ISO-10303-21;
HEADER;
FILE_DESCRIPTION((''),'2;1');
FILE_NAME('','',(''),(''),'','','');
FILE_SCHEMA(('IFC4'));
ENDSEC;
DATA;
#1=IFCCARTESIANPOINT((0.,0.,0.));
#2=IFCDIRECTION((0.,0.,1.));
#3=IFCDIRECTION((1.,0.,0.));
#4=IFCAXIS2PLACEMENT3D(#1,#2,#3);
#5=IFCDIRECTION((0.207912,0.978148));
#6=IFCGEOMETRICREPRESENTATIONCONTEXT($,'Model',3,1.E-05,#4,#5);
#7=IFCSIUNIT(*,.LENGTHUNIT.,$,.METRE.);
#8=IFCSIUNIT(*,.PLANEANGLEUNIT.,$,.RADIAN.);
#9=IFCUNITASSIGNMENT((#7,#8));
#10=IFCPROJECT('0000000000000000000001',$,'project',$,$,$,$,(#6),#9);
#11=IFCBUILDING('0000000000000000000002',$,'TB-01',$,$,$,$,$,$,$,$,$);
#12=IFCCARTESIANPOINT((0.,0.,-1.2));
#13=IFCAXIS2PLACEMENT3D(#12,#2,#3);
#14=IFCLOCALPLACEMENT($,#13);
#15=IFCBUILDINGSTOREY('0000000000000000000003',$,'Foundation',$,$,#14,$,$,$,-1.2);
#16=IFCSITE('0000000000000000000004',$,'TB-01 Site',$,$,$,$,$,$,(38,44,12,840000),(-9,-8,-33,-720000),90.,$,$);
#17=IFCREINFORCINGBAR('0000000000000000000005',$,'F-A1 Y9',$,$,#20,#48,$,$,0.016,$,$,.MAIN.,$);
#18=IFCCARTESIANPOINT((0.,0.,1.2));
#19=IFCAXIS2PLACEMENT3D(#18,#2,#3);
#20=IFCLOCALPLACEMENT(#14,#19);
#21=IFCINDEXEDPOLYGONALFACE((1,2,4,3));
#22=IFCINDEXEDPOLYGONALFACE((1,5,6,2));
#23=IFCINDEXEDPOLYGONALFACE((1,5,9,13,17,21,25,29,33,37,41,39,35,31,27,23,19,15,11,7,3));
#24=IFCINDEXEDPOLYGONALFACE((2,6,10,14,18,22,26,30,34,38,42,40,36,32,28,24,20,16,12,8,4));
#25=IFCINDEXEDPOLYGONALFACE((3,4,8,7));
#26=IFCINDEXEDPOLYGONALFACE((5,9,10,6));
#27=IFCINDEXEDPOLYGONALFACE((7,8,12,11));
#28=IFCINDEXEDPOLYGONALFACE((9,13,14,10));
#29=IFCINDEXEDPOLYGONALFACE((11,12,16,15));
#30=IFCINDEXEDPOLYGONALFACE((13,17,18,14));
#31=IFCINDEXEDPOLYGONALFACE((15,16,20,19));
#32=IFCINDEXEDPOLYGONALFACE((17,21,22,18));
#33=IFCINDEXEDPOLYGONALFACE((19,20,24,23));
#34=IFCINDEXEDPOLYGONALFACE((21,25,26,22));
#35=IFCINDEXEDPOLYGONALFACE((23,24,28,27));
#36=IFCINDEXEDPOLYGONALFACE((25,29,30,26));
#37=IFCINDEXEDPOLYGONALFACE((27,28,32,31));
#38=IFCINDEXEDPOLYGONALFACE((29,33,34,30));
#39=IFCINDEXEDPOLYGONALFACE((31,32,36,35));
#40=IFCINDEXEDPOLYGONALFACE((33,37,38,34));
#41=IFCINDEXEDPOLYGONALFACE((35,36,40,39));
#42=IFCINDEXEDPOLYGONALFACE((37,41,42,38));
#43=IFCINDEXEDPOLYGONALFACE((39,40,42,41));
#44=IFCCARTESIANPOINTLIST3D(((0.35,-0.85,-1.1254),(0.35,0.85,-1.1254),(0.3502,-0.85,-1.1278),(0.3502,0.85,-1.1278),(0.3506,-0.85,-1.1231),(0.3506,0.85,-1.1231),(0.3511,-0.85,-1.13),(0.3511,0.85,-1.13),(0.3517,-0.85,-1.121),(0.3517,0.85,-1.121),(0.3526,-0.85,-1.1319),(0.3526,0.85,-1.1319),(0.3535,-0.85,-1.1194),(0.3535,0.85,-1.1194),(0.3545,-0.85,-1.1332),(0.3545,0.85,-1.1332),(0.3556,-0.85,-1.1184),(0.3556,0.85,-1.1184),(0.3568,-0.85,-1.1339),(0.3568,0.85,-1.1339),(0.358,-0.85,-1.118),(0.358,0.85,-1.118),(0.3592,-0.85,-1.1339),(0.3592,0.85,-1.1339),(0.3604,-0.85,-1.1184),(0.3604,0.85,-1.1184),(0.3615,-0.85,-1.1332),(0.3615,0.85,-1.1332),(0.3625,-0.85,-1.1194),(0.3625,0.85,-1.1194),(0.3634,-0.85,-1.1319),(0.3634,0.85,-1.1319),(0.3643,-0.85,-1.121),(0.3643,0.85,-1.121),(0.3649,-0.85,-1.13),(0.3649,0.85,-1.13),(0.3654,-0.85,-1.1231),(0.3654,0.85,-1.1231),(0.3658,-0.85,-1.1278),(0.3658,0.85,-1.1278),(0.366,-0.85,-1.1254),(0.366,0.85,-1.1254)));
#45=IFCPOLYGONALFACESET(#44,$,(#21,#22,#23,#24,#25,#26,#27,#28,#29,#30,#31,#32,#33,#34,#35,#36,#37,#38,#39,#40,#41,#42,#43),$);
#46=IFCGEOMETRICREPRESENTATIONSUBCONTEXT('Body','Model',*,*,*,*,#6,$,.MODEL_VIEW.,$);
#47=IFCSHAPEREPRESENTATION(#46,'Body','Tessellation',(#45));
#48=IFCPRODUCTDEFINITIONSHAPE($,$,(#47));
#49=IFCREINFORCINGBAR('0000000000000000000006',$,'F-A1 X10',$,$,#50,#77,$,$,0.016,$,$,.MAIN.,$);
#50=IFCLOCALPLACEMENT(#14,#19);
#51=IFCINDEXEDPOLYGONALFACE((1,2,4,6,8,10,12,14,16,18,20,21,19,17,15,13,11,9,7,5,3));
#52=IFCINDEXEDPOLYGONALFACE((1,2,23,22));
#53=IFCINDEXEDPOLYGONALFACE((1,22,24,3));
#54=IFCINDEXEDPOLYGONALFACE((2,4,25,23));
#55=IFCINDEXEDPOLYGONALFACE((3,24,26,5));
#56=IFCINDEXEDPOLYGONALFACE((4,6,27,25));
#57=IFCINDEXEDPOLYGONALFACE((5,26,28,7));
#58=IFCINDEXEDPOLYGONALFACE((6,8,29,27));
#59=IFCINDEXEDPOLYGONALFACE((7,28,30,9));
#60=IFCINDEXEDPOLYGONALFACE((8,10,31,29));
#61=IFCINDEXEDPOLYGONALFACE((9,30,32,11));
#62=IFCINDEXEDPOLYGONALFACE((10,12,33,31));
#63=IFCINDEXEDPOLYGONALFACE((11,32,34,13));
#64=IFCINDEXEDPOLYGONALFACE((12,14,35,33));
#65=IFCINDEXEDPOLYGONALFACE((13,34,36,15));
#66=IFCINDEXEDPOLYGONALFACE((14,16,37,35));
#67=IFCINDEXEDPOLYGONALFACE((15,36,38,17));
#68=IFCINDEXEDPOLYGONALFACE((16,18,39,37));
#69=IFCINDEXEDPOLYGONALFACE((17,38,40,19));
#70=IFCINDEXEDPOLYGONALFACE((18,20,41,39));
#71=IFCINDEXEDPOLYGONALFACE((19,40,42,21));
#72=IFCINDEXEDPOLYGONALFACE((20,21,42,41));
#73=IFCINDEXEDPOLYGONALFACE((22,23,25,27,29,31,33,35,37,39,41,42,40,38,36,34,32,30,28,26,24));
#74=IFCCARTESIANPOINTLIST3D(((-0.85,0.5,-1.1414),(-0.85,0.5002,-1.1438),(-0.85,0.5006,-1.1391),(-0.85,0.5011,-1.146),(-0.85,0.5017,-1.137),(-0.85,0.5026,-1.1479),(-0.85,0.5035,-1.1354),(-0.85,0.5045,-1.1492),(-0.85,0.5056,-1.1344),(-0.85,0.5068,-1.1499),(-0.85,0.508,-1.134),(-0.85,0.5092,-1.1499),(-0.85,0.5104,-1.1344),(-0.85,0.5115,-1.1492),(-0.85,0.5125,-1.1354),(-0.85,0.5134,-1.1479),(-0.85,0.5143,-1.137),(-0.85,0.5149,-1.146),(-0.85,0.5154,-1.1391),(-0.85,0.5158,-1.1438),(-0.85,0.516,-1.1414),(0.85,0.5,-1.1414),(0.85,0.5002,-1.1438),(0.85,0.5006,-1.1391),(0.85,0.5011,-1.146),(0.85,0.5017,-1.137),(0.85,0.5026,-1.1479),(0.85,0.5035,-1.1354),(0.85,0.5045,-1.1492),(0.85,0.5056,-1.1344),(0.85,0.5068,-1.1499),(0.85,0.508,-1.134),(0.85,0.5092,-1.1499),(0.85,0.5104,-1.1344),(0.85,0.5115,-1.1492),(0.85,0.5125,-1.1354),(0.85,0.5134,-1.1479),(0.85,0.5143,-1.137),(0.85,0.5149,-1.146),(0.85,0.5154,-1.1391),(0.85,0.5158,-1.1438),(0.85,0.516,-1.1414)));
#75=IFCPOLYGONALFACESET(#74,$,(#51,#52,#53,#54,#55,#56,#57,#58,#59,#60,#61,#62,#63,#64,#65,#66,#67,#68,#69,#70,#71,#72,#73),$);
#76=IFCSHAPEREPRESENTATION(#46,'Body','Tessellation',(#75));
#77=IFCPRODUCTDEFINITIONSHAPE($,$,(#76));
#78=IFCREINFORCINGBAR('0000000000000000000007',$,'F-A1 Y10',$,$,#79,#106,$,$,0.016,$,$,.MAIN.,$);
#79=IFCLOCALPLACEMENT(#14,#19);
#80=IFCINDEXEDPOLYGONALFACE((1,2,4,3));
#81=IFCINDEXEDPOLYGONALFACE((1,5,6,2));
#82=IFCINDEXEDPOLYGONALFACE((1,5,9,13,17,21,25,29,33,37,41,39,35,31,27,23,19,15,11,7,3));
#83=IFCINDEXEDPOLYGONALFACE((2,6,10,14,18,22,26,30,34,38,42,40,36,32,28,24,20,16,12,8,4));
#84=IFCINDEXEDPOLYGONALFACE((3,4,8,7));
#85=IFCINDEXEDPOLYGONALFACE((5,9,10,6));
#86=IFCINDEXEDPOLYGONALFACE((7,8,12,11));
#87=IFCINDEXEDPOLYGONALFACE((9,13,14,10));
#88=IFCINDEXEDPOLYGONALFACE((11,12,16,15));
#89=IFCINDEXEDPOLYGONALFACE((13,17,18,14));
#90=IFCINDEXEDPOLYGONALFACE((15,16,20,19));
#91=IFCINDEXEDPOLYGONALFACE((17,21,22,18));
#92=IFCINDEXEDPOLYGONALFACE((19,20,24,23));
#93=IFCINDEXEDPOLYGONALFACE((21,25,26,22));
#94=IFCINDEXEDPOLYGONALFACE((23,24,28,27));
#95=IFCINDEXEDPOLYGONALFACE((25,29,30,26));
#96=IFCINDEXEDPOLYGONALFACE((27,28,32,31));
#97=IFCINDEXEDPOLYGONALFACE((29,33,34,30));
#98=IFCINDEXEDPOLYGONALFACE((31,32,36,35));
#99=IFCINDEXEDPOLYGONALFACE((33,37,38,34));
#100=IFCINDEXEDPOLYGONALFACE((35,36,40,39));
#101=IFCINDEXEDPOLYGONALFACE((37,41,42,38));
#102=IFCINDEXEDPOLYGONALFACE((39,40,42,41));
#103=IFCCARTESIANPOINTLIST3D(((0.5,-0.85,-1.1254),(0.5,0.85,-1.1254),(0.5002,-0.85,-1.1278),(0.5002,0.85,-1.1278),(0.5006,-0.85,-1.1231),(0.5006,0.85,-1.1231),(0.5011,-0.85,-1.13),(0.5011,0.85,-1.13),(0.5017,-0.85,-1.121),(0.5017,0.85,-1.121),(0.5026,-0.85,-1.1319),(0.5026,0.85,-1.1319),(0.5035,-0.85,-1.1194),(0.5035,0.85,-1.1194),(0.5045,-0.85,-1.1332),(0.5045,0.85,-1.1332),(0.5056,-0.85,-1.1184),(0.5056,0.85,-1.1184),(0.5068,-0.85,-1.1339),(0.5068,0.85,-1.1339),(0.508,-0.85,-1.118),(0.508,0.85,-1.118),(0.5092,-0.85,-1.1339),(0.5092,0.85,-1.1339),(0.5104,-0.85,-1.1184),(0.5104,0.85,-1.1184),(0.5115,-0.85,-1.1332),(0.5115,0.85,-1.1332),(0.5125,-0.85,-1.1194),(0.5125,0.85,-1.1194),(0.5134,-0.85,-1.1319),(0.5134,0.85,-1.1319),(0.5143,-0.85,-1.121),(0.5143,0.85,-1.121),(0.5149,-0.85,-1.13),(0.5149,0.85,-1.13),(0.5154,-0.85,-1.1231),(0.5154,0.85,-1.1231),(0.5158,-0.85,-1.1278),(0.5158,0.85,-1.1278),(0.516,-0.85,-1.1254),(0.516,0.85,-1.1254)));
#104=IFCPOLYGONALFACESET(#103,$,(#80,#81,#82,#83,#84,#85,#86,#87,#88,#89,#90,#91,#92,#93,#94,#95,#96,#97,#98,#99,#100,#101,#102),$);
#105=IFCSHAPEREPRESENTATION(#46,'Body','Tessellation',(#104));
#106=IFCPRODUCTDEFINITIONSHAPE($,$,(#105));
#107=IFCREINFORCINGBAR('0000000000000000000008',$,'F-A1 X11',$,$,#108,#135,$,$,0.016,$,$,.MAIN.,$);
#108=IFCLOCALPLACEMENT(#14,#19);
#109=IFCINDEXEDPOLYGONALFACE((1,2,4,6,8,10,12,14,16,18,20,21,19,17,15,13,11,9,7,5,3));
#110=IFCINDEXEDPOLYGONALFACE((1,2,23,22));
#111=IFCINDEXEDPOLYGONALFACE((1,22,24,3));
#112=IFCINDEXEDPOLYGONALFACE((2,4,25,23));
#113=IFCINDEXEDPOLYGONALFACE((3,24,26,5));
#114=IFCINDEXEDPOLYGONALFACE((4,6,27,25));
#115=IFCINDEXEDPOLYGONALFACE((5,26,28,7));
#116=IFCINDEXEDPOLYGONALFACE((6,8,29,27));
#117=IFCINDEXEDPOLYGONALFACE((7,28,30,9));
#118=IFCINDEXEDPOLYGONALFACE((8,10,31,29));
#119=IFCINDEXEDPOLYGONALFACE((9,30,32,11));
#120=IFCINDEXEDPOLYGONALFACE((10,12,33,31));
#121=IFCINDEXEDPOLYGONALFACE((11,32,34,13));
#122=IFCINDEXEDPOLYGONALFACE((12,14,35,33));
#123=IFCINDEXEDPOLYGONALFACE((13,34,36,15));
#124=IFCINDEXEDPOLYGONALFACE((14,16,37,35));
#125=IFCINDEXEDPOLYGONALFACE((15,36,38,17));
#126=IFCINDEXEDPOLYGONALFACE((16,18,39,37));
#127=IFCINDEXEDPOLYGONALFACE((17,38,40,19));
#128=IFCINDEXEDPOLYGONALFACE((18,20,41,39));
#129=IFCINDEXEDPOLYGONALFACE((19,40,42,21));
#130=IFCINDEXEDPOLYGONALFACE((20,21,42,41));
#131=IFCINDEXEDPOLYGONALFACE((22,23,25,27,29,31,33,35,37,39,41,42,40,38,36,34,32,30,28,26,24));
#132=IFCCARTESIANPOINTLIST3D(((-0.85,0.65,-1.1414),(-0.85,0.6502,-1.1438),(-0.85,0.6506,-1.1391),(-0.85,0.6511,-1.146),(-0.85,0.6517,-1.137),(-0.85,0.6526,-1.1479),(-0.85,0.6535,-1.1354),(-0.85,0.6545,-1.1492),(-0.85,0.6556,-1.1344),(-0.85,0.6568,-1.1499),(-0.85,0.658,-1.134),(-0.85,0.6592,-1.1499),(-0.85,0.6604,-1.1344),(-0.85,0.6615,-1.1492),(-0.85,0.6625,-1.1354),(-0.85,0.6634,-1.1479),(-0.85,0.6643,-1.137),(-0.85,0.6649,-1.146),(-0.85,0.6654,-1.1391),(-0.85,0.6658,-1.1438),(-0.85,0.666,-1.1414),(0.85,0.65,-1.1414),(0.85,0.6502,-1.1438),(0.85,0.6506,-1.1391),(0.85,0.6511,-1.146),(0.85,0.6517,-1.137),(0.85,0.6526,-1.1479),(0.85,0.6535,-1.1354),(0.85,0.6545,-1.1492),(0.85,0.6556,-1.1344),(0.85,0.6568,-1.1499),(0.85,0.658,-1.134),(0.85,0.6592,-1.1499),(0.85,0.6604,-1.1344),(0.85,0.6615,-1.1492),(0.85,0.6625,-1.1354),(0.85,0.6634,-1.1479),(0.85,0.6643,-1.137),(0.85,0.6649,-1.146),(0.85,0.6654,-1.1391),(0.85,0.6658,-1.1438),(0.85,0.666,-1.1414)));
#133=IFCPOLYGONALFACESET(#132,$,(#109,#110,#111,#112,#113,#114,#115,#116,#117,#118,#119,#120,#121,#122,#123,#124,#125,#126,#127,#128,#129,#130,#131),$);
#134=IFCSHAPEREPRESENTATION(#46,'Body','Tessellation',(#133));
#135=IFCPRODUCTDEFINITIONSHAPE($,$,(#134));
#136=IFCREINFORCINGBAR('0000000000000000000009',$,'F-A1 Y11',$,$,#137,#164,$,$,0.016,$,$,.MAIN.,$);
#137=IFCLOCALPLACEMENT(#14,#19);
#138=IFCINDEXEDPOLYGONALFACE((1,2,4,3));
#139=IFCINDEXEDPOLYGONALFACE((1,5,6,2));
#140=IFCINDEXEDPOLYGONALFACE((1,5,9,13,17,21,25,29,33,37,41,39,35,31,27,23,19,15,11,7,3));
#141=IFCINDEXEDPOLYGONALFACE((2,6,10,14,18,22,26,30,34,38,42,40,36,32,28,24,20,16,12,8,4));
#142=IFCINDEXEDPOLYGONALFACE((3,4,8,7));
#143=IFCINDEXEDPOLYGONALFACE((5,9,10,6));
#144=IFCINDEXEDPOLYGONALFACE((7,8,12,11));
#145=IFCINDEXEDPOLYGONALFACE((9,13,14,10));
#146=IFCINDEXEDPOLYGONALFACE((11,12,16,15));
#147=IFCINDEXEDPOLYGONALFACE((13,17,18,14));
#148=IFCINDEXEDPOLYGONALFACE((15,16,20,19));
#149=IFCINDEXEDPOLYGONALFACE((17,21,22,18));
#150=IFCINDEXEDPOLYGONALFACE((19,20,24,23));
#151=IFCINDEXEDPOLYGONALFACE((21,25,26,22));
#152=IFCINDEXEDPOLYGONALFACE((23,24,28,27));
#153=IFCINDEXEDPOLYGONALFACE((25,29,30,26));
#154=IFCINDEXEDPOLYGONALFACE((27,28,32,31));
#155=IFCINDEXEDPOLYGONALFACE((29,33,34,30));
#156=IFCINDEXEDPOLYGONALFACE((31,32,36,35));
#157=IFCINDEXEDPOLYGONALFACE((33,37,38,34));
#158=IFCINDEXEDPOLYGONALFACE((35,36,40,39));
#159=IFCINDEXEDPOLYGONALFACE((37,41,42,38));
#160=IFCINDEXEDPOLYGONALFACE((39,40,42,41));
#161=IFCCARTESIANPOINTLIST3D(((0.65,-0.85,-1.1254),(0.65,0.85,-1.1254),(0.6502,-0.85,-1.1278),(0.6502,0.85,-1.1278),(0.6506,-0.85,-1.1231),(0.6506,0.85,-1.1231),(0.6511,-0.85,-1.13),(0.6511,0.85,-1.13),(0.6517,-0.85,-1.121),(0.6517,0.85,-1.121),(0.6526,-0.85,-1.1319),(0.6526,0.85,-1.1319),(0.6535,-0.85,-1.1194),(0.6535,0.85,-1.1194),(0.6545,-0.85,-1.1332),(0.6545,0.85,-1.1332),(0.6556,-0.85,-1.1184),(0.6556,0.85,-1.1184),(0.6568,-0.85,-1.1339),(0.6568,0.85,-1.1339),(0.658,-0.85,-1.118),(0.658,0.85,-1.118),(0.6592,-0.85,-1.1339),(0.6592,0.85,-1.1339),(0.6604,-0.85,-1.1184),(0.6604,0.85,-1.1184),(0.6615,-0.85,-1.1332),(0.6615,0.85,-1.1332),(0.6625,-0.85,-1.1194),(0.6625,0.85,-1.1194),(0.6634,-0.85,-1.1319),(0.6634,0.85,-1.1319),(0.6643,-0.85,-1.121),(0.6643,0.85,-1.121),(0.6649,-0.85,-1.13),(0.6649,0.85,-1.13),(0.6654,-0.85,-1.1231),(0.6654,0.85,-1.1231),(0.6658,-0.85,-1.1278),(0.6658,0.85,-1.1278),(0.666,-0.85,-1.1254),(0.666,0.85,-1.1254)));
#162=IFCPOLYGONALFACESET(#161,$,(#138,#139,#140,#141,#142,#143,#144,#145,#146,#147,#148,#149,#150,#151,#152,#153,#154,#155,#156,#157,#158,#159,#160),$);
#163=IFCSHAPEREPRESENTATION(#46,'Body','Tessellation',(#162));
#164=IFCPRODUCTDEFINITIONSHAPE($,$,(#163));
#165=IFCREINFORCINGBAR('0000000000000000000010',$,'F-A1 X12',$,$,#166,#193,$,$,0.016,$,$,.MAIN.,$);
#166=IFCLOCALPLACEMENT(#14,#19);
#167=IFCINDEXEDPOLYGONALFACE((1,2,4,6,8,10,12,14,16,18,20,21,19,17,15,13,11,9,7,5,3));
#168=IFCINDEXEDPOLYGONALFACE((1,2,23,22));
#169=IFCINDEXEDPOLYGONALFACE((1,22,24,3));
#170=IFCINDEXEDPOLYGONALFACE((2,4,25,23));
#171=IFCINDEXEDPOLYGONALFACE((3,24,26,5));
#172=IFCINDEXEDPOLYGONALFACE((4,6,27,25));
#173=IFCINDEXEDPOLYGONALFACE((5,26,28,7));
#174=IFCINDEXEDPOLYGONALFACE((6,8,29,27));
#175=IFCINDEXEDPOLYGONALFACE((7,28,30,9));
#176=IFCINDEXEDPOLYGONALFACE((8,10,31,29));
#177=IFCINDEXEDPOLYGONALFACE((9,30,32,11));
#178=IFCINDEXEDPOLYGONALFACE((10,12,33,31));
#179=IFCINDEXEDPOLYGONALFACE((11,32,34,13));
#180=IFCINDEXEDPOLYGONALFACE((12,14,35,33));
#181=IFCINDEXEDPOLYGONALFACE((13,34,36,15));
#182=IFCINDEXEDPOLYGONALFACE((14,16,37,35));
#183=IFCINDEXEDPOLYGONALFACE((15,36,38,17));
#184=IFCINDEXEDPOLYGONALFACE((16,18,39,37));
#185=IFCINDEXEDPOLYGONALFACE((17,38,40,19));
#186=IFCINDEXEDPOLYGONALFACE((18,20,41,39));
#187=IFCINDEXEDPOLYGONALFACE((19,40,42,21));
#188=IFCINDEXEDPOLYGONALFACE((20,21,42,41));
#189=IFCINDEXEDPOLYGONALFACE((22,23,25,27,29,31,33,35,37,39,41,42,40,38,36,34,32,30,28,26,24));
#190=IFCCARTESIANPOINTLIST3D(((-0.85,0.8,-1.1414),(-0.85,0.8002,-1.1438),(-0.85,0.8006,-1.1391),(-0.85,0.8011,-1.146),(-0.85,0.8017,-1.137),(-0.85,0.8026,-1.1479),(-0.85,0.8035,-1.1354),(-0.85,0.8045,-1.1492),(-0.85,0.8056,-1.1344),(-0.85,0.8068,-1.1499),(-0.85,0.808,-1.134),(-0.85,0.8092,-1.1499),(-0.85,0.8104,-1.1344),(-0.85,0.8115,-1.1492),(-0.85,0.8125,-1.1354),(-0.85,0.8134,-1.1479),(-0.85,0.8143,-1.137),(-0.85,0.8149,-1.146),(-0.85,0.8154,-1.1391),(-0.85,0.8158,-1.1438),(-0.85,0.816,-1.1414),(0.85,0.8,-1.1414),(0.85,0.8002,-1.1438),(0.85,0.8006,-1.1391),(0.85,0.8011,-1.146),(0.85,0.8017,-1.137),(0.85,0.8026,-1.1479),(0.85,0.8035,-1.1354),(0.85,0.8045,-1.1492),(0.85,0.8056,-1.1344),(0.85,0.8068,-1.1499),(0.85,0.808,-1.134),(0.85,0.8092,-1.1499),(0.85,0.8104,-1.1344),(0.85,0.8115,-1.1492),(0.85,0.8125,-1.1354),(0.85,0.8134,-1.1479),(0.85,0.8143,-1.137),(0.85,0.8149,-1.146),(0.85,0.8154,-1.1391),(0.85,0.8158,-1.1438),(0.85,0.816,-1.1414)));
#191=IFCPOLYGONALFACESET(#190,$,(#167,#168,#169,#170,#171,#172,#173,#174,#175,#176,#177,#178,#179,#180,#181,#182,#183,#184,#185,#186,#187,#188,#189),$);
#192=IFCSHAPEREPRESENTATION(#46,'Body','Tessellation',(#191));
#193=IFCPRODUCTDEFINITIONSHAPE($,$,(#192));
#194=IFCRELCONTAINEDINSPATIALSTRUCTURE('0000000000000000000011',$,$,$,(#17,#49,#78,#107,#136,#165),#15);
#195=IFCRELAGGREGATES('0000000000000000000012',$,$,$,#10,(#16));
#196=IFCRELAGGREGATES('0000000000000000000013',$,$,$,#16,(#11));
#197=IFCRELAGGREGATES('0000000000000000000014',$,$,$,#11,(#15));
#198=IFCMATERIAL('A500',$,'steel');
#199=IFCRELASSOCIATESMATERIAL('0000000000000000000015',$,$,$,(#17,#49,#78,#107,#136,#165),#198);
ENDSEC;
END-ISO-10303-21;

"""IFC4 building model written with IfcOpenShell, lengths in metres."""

from ifc_helpers import new_model, entity, si_unit, direction, frame, origin_with_axes, place, context, subcontext, project, spatial, material, element, save


model = new_model("IFC4")

# Units and contexts
model_context = context("Model", 3, precision=1e-05, world=origin_with_axes(), true_north=direction((0.207912, 0.978148)))
body_context = subcontext(model_context, "Body", "Model", "MODEL_VIEW")
ifc_project = project(units=[si_unit("LENGTHUNIT", "METRE"), si_unit("PLANEANGLEUNIT", "RADIAN")], contexts=[model_context])

# Site, building, storey
site = spatial("IfcSite", under=ifc_project, Name="TB-01 Site", RefLatitude=(38, 44, 12, 840000), RefLongitude=(-9, -8, -33, -720000), RefElevation=90.0)
building = spatial("IfcBuilding", under=site, Name="TB-01")
storey_placement = place(None, frame((0.0, 0.0, -1.2), z_axis=(0.0, 0.0, 1.0), x_axis=(1.0, 0.0, 0.0)))
storey = spatial("IfcBuildingStorey", under=building, at=storey_placement, Name="Foundation", Elevation=-1.2)

# Reinforcing bars
ifc_material_1 = material(Name="A500", Category="steel")
reinforcing_bar_1_placement = place(storey_placement, frame((0.0, 0.0, 1.2), z_axis=(0.0, 0.0, 1.0), x_axis=(1.0, 0.0, 0.0)))
element("IfcReinforcingBar", 1, at=reinforcing_bar_1_placement, inside=storey, material=ifc_material_1, Name="F-A1 Y9", NominalDiameter=0.016, PredefinedType="MAIN", context=body_context, shape_type="AdvancedSweptSolid", body=[
    entity("IfcSweptDiskSolid", entity("IfcPolyline", [entity("IfcCartesianPoint", [0.358, -0.85, -1.126]), entity("IfcCartesianPoint", [0.358, 0.85, -1.126])]), 0.008),
])
reinforcing_bar_2_placement = place(storey_placement, frame((0.0, 0.0, 1.2), z_axis=(0.0, 0.0, 1.0), x_axis=(1.0, 0.0, 0.0)))
element("IfcReinforcingBar", 2, at=reinforcing_bar_2_placement, inside=storey, material=ifc_material_1, Name="F-A1 X10", NominalDiameter=0.016, PredefinedType="MAIN", context=body_context, shape_type="AdvancedSweptSolid", body=[
    entity("IfcSweptDiskSolid", entity("IfcPolyline", [entity("IfcCartesianPoint", [-0.85, 0.508, -1.142]), entity("IfcCartesianPoint", [0.85, 0.508, -1.142])]), 0.008),
])
reinforcing_bar_3_placement = place(storey_placement, frame((0.0, 0.0, 1.2), z_axis=(0.0, 0.0, 1.0), x_axis=(1.0, 0.0, 0.0)))
element("IfcReinforcingBar", 3, at=reinforcing_bar_3_placement, inside=storey, material=ifc_material_1, Name="F-A1 Y10", NominalDiameter=0.016, PredefinedType="MAIN", context=body_context, shape_type="AdvancedSweptSolid", body=[
    entity("IfcSweptDiskSolid", entity("IfcPolyline", [entity("IfcCartesianPoint", [0.508, -0.85, -1.126]), entity("IfcCartesianPoint", [0.508, 0.85, -1.126])]), 0.008),
])
reinforcing_bar_4_placement = place(storey_placement, frame((0.0, 0.0, 1.2), z_axis=(0.0, 0.0, 1.0), x_axis=(1.0, 0.0, 0.0)))
element("IfcReinforcingBar", 4, at=reinforcing_bar_4_placement, inside=storey, material=ifc_material_1, Name="F-A1 X11", NominalDiameter=0.016, PredefinedType="MAIN", context=body_context, shape_type="AdvancedSweptSolid", body=[
    entity("IfcSweptDiskSolid", entity("IfcPolyline", [entity("IfcCartesianPoint", [-0.85, 0.658, -1.142]), entity("IfcCartesianPoint", [0.85, 0.658, -1.142])]), 0.008),
])
reinforcing_bar_5_placement = place(storey_placement, frame((0.0, 0.0, 1.2), z_axis=(0.0, 0.0, 1.0), x_axis=(1.0, 0.0, 0.0)))
element("IfcReinforcingBar", 5, at=reinforcing_bar_5_placement, inside=storey, material=ifc_material_1, Name="F-A1 Y11", NominalDiameter=0.016, PredefinedType="MAIN", context=body_context, shape_type="AdvancedSweptSolid", body=[
    entity("IfcSweptDiskSolid", entity("IfcPolyline", [entity("IfcCartesianPoint", [0.658, -0.85, -1.126]), entity("IfcCartesianPoint", [0.658, 0.85, -1.126])]), 0.008),
])
reinforcing_bar_6_placement = place(storey_placement, frame((0.0, 0.0, 1.2), z_axis=(0.0, 0.0, 1.0), x_axis=(1.0, 0.0, 0.0)))
element("IfcReinforcingBar", 6, at=reinforcing_bar_6_placement, inside=storey, material=ifc_material_1, Name="F-A1 X12", NominalDiameter=0.016, PredefinedType="MAIN", context=body_context, shape_type="AdvancedSweptSolid", body=[
    entity("IfcSweptDiskSolid", entity("IfcPolyline", [entity("IfcCartesianPoint", [-0.85, 0.808, -1.142]), entity("IfcCartesianPoint", [0.85, 0.808, -1.142])]), 0.008),
])

save(model, "model.ifc")
